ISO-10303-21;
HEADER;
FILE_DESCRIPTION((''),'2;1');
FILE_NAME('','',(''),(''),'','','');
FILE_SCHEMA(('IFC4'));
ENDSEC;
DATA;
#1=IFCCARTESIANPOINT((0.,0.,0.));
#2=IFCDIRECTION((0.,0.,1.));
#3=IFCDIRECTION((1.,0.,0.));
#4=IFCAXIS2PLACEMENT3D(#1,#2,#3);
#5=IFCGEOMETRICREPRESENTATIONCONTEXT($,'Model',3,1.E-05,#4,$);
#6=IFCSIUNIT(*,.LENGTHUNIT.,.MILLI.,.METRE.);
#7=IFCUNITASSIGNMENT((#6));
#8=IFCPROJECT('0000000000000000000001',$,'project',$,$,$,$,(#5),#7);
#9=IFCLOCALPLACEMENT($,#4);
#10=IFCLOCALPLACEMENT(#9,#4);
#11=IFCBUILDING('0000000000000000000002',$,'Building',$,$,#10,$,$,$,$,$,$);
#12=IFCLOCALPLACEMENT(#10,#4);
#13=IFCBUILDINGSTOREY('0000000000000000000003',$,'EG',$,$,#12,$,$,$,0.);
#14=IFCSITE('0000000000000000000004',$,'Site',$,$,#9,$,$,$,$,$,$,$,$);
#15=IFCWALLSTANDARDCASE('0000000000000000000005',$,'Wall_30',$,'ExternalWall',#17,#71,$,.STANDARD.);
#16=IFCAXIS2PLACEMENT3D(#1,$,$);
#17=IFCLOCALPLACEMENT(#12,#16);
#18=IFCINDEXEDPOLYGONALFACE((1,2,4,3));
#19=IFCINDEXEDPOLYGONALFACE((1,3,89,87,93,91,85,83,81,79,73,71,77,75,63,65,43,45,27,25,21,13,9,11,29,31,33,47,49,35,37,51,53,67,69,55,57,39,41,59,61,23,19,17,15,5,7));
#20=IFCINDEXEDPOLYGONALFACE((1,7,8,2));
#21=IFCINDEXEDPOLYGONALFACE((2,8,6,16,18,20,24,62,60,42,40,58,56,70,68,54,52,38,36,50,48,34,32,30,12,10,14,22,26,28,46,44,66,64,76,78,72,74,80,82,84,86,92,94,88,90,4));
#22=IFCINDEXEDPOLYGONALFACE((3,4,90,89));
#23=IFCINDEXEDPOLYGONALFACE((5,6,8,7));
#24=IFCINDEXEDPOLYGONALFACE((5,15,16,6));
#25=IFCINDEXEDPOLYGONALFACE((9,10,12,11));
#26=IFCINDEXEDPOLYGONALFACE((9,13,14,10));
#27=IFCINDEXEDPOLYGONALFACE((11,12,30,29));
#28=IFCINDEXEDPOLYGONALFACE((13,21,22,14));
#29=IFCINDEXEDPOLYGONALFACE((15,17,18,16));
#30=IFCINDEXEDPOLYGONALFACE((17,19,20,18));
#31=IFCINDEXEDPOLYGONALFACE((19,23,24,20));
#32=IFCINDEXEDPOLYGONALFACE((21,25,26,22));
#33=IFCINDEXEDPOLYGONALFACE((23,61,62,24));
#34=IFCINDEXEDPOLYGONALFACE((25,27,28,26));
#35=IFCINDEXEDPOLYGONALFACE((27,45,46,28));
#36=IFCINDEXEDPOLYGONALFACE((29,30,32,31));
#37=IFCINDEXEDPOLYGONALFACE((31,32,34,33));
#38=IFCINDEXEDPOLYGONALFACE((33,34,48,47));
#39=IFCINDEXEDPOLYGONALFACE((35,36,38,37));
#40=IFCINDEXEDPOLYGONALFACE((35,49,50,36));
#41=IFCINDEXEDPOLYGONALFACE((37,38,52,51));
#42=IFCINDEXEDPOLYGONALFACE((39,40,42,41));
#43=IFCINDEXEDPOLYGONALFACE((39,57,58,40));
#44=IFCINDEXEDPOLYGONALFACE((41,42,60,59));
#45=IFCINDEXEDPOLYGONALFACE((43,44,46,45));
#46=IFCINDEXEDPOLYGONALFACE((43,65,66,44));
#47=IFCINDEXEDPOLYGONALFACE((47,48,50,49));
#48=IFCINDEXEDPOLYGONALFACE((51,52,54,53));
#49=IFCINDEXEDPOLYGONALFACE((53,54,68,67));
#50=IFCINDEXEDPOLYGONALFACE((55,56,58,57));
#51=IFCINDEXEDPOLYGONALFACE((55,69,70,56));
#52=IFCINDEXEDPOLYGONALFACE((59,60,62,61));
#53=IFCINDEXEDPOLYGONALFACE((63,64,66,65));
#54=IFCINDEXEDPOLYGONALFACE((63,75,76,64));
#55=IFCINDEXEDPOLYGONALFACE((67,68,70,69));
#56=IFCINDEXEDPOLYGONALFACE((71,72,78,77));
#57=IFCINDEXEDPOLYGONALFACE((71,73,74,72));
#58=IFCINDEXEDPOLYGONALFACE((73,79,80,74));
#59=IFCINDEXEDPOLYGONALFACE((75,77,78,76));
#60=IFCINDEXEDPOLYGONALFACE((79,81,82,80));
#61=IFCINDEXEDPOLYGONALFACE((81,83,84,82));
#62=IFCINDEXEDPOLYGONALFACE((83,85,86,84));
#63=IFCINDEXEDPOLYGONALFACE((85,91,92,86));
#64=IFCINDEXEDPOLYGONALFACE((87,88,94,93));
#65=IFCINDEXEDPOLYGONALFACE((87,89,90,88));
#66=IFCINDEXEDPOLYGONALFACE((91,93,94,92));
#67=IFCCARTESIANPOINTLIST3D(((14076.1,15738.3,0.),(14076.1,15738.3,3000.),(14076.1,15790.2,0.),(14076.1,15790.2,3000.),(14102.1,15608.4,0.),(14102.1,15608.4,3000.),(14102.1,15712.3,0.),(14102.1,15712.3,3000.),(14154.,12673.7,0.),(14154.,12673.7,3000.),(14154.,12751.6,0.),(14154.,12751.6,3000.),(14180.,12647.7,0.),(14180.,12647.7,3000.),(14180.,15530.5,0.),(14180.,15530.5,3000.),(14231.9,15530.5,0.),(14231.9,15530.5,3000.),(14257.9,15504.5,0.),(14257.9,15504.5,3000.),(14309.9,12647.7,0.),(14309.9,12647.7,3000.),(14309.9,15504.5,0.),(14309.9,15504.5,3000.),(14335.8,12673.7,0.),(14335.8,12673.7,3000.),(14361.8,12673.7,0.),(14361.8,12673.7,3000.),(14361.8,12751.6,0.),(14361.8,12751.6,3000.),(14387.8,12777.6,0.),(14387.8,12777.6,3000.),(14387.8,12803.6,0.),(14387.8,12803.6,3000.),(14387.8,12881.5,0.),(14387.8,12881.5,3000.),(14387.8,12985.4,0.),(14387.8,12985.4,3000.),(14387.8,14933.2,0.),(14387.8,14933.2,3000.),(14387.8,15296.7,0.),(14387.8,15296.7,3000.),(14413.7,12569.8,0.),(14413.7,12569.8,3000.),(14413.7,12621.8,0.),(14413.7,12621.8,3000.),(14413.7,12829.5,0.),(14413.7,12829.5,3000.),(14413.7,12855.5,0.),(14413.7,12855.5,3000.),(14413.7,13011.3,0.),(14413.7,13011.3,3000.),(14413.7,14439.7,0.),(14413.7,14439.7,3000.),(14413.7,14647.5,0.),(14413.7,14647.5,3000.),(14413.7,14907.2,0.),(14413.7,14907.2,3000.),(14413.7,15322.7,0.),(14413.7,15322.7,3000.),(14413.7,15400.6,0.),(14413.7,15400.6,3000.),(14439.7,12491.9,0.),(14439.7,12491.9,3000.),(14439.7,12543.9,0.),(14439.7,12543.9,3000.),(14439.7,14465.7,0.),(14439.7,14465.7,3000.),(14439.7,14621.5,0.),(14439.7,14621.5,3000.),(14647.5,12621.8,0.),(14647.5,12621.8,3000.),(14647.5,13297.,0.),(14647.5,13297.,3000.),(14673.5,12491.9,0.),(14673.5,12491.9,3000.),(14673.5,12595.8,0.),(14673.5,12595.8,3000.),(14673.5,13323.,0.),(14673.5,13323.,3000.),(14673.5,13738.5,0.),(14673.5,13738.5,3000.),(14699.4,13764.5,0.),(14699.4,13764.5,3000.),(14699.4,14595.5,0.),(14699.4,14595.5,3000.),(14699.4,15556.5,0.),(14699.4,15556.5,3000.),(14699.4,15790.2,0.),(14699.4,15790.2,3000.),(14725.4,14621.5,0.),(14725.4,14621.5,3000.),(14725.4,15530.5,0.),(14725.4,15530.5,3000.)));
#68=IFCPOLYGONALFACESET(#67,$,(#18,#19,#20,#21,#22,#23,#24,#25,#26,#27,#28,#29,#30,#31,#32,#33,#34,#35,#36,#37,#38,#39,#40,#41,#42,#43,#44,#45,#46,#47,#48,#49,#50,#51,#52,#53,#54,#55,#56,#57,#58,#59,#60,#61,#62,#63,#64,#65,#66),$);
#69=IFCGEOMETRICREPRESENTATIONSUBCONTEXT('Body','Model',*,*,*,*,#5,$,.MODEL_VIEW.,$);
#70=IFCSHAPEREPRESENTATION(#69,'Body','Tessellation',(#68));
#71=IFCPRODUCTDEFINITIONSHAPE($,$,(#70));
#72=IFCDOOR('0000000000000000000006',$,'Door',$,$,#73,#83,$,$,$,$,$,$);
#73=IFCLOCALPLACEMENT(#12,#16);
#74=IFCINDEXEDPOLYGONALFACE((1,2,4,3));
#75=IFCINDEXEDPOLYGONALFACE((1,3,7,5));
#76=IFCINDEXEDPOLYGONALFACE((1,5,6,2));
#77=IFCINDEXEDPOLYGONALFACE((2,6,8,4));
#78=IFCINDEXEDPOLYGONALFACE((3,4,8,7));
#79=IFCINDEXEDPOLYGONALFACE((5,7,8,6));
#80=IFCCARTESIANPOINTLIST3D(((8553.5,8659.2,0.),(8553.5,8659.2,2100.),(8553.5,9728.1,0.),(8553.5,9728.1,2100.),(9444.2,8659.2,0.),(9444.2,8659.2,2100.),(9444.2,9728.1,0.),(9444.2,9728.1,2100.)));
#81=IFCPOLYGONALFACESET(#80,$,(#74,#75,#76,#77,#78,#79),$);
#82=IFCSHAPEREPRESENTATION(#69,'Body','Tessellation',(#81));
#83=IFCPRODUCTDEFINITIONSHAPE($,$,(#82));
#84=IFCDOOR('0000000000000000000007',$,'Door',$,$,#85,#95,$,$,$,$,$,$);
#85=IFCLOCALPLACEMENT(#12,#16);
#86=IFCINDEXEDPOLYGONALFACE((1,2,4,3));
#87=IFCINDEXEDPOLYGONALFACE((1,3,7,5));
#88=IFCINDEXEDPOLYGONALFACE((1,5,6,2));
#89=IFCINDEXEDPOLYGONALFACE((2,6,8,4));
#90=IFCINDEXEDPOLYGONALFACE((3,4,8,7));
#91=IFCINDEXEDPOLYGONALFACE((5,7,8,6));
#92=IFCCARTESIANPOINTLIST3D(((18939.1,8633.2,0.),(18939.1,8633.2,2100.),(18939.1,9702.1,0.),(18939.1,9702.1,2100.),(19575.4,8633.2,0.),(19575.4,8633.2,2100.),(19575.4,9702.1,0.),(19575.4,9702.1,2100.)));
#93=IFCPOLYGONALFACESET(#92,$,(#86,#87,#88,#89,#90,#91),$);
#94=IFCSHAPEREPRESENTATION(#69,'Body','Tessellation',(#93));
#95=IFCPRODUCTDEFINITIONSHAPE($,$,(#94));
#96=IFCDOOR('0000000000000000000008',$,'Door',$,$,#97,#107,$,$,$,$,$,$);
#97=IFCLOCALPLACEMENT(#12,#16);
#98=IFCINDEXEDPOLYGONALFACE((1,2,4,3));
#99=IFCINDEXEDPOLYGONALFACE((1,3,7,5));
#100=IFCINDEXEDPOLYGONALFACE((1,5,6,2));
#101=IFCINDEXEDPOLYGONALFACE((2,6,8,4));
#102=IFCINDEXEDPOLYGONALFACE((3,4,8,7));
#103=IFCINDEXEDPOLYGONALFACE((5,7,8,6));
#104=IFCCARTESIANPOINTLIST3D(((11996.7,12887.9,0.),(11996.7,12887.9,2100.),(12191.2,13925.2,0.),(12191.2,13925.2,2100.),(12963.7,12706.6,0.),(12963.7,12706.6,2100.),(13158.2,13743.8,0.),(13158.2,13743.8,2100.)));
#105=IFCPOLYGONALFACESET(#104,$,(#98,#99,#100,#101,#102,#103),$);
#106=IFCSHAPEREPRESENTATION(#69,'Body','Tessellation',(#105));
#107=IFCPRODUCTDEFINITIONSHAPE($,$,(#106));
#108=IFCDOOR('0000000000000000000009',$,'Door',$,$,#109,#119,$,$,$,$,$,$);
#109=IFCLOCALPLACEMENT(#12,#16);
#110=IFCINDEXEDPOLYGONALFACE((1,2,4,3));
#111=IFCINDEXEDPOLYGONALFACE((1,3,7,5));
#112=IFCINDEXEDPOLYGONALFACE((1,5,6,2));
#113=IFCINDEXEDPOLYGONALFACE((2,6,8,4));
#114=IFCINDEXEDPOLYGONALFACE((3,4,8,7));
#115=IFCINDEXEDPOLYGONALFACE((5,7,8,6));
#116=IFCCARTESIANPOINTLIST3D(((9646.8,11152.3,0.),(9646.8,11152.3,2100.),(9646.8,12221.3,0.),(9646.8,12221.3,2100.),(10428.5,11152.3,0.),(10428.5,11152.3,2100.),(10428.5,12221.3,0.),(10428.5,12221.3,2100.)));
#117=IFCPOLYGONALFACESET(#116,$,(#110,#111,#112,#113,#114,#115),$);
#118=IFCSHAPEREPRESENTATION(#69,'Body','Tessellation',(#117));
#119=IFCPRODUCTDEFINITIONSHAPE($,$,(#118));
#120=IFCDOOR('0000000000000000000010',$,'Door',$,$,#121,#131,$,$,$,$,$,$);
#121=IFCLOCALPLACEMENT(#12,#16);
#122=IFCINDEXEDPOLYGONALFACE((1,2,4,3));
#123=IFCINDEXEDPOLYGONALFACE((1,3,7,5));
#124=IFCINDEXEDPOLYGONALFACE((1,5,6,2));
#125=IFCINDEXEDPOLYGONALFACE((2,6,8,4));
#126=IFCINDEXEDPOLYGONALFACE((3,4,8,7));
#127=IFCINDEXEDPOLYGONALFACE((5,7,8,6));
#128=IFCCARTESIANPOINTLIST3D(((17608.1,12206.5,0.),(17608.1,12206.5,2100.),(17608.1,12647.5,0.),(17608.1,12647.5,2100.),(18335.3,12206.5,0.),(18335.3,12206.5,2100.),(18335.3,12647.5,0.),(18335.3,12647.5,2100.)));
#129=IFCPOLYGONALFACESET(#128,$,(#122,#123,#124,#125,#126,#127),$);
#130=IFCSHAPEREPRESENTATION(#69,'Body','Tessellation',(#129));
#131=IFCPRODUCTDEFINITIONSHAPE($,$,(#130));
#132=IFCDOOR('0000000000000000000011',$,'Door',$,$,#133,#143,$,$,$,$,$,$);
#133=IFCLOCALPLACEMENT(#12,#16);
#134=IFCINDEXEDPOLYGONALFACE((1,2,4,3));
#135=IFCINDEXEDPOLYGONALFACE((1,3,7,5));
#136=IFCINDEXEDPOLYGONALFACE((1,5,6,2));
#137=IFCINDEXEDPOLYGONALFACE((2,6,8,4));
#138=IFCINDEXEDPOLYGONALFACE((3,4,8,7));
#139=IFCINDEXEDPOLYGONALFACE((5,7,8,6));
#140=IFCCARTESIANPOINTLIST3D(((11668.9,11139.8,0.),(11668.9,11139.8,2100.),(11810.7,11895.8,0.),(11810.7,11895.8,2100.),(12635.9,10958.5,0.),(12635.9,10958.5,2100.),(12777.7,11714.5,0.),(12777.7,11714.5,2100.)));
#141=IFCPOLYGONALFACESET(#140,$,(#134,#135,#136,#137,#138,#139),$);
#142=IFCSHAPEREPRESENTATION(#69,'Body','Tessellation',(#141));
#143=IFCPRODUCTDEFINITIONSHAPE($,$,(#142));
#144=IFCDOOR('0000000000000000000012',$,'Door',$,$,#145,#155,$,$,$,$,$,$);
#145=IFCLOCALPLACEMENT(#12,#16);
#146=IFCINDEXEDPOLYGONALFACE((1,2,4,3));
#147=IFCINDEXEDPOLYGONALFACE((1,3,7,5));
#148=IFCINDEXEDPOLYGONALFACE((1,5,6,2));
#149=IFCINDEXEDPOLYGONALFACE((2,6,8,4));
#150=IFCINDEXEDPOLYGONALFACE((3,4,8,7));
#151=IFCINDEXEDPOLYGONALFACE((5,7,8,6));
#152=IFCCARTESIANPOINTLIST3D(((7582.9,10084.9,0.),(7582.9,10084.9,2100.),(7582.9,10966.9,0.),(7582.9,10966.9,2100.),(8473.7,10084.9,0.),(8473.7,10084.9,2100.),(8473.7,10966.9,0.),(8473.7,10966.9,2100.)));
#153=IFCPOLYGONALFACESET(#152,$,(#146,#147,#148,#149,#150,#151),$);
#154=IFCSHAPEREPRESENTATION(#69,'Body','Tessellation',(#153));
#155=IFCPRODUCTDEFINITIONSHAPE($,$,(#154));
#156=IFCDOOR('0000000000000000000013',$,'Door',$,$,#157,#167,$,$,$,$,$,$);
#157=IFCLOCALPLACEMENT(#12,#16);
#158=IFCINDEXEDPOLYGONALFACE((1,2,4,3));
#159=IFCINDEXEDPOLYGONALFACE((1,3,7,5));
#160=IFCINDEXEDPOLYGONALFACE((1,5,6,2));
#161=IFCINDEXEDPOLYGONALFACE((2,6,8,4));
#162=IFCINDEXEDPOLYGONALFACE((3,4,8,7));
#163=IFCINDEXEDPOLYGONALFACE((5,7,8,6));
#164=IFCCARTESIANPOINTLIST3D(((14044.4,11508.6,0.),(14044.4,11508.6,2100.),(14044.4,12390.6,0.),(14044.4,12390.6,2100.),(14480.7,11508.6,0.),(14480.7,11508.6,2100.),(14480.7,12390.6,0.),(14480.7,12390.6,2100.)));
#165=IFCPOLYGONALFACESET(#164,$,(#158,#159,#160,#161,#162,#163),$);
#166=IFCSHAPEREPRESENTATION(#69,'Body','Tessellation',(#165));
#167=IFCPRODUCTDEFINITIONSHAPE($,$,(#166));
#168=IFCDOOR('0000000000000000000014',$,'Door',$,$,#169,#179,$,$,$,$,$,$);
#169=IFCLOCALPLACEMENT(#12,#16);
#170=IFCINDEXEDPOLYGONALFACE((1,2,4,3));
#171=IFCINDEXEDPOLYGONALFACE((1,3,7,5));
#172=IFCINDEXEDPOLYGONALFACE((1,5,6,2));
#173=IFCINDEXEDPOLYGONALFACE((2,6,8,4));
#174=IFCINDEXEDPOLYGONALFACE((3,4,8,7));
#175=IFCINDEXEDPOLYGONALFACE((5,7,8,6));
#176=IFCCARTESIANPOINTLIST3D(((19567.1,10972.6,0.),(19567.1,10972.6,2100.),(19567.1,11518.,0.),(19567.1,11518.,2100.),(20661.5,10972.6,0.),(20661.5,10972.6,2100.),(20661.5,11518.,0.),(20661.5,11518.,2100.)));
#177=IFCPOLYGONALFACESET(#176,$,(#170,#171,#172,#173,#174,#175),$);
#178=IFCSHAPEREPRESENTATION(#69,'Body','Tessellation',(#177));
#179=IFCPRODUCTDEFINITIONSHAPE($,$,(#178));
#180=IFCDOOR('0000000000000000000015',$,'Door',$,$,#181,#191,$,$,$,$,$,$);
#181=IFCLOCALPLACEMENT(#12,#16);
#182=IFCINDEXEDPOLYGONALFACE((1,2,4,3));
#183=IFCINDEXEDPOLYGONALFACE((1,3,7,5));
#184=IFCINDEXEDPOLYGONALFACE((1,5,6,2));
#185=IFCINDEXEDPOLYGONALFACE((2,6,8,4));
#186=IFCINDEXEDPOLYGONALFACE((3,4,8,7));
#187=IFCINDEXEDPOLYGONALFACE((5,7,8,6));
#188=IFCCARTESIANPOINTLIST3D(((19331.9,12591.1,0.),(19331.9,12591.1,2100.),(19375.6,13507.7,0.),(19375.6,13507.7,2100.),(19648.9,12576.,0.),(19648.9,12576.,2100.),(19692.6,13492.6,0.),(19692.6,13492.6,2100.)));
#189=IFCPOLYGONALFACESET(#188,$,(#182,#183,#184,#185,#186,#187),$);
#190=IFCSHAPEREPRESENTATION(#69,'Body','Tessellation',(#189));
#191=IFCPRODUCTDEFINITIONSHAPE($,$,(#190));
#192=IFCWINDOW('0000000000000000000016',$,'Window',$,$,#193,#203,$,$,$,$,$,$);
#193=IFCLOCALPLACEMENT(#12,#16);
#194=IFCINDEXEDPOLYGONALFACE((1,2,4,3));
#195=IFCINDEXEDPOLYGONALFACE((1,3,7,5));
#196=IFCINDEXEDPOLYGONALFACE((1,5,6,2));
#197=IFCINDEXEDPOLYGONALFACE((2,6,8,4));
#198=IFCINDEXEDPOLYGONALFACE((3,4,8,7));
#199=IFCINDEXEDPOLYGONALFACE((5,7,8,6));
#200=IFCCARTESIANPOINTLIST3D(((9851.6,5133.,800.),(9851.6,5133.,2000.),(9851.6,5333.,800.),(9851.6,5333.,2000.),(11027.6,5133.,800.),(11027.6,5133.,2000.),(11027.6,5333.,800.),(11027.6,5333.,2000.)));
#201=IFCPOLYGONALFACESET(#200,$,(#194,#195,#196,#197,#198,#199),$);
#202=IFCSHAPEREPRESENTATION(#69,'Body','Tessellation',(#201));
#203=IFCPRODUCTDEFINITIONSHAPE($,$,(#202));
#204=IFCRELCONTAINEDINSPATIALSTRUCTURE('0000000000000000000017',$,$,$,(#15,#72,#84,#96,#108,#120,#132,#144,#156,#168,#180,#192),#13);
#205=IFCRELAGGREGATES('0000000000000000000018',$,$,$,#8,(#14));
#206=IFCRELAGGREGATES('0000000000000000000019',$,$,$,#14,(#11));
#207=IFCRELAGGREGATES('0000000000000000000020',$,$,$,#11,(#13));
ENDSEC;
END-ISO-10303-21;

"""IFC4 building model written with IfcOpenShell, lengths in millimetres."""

from ifc_helpers import new_model, si_unit, frame, origin_with_axes, place, context, subcontext, project, spatial, polyline, rectangle, outline, extrude, element, save


model = new_model("IFC4")

# Units and contexts
model_context = context("Model", 3, precision=1e-05, world=origin_with_axes())
body_context = subcontext(model_context, "Body", "Model", "MODEL_VIEW")
ifc_project = project(units=[si_unit("LENGTHUNIT", "METRE", prefix="MILLI")], contexts=[model_context])

# Site, building, storey
site_placement = place(None, origin_with_axes())
site = spatial("IfcSite", under=ifc_project, at=site_placement, Name="Site")
building_placement = place(site_placement, origin_with_axes())
building = spatial("IfcBuilding", under=site, at=building_placement, Name="Building")
storey_placement = place(building_placement, origin_with_axes())
storey = spatial("IfcBuildingStorey", under=building, at=storey_placement, Name="EG", Elevation=0.0)

# Wall
wall_placement = place(storey_placement, origin_with_axes())
element("IfcWallStandardCase", 1, at=wall_placement, inside=storey, Name="Wall_30", ObjectType="ExternalWall", PredefinedType="STANDARD", context=body_context, shape_type="SweptSolid", body=[
    extrude(outline(polyline([(14439.7, 12491.9, 0.0), (14439.7, 12543.9, 0.0), (14413.7, 12569.8, 0.0), (14413.7, 12621.8, 0.0), (14361.8, 12673.7, 0.0), (14335.8, 12673.7, 0.0), (14309.9, 12647.7, 0.0), (14180.0, 12647.7, 0.0), (14154.0, 12673.7, 0.0), (14154.0, 12751.6, 0.0), (14361.8, 12751.6, 0.0), (14387.8, 12777.6, 0.0), (14387.8, 12803.6, 0.0), (14413.7, 12829.5, 0.0), (14413.7, 12855.5, 0.0), (14387.8, 12881.5, 0.0), (14387.8, 12985.4, 0.0), (14413.7, 13011.3, 0.0), (14413.7, 14439.7, 0.0), (14439.7, 14465.7, 0.0), (14439.7, 14621.5, 0.0), (14413.7, 14647.5, 0.0), (14413.7, 14907.2, 0.0), (14387.8, 14933.2, 0.0), (14387.8, 15296.7, 0.0), (14413.7, 15322.7, 0.0), (14413.7, 15400.6, 0.0), (14309.9, 15504.5, 0.0), (14257.9, 15504.5, 0.0), (14231.9, 15530.5, 0.0), (14180.0, 15530.5, 0.0), (14102.1, 15608.4, 0.0), (14102.1, 15712.3, 0.0), (14076.1, 15738.3, 0.0), (14076.1, 15790.2, 0.0), (14699.4, 15790.2, 0.0), (14699.4, 15556.5, 0.0), (14725.4, 15530.5, 0.0), (14725.4, 14621.5, 0.0), (14699.4, 14595.5, 0.0), (14699.4, 13764.5, 0.0), (14673.5, 13738.5, 0.0), (14673.5, 13323.0, 0.0), (14647.5, 13297.0, 0.0), (14647.5, 12621.8, 0.0), (14673.5, 12595.8, 0.0), (14673.5, 12491.9, 0.0), (14439.7, 12491.9, 0.0)])), origin_with_axes(), (0.0, 0.0, 1.0), 3000.0),
])

# Doors
door_1_placement = place(storey_placement, origin_with_axes())
element("IfcDoor", 2, at=door_1_placement, inside=storey, Name="Door", context=body_context, shape_type="SweptSolid", body=[
    extrude(rectangle(XDim=1069.0, YDim=890.8), frame((8998.9, 9193.6, 0.0), z_axis=(0.0, 0.0, 1.0), x_axis=(0.0, 1.0, 0.0)), (0.0, 0.0, 1.0), 2100.0),
])
door_2_placement = place(storey_placement, origin_with_axes())
element("IfcDoor", 3, at=door_2_placement, inside=storey, Name="Door", context=body_context, shape_type="SweptSolid", body=[
    extrude(rectangle(XDim=1069.0, YDim=636.3), frame((19257.3, 9167.7, 0.0), z_axis=(0.0, 0.0, 1.0), x_axis=(0.0, -1.0, 0.0)), (0.0, 0.0, 1.0), 2100.0),
])
door_3_placement = place(storey_placement, origin_with_axes())
element("IfcDoor", 4, at=door_3_placement, inside=storey, Name="Door", context=body_context, shape_type="SweptSolid", body=[
    extrude(rectangle(XDim=1055.3, YDim=983.9), frame((12577.4, 13315.9, 0.0), z_axis=(0.0, 0.0, 1.0), x_axis=(0.184288, 0.982872, 0.0)), (0.0, 0.0, 1.0), 2100.0),
])
door_4_placement = place(storey_placement, origin_with_axes())
element("IfcDoor", 5, at=door_4_placement, inside=storey, Name="Door", context=body_context, shape_type="SweptSolid", body=[
    extrude(rectangle(XDim=1069.0, YDim=781.7), frame((10037.7, 11686.8, 0.0), z_axis=(0.0, 0.0, 1.0), x_axis=(0.0, -1.0, 0.0)), (0.0, 0.0, 1.0), 2100.0),
])
door_5_placement = place(storey_placement, origin_with_axes())
element("IfcDoor", 6, at=door_5_placement, inside=storey, Name="Door", context=body_context, shape_type="SweptSolid", body=[
    extrude(rectangle(XDim=441.0, YDim=727.2), frame((17971.7, 12427.0, 0.0), z_axis=(0.0, 0.0, 1.0), x_axis=(0.0, 1.0, 0.0)), (0.0, 0.0, 1.0), 2100.0),
])
door_6_placement = place(storey_placement, origin_with_axes())
element("IfcDoor", 7, at=door_6_placement, inside=storey, Name="Door", context=body_context, shape_type="SweptSolid", body=[
    extrude(rectangle(XDim=769.2, YDim=983.9), frame((12223.3, 11427.2, 0.0), z_axis=(0.0, 0.0, 1.0), x_axis=(0.184288, 0.982872, 0.0)), (0.0, 0.0, 1.0), 2100.0),
])
door_7_placement = place(storey_placement, origin_with_axes())
element("IfcDoor", 8, at=door_7_placement, inside=storey, Name="Door", context=body_context, shape_type="SweptSolid", body=[
    extrude(rectangle(XDim=882.0, YDim=890.8), frame((8028.3, 10525.9, 0.0), z_axis=(0.0, 0.0, 1.0), x_axis=(0.0, 1.0, 0.0)), (0.0, 0.0, 1.0), 2100.0),
])
door_8_placement = place(storey_placement, origin_with_axes())
element("IfcDoor", 9, at=door_8_placement, inside=storey, Name="Door", context=body_context, shape_type="SweptSolid", body=[
    extrude(rectangle(XDim=882.0, YDim=436.3), frame((14262.5, 11949.6, 0.0), z_axis=(0.0, 0.0, 1.0), x_axis=(0.0, -1.0, 0.0)), (0.0, 0.0, 1.0), 2100.0),
])
door_9_placement = place(storey_placement, origin_with_axes())
element("IfcDoor", 10, at=door_9_placement, inside=storey, Name="Door", context=body_context, shape_type="SweptSolid", body=[
    extrude(rectangle(XDim=1094.4, YDim=545.4), frame((20114.3, 11245.3, 0.0), z_axis=(0.0, 0.0, 1.0), x_axis=(1.0, 0.0, 0.0)), (0.0, 0.0, 1.0), 2100.0),
])
door_10_placement = place(storey_placement, origin_with_axes())
element("IfcDoor", 11, at=door_10_placement, inside=storey, Name="Door", context=body_context, shape_type="SweptSolid", body=[
    extrude(rectangle(XDim=917.6, YDim=317.3), frame((19512.3, 13041.9, 0.0), z_axis=(0.0, 0.0, 1.0), x_axis=(-0.047565, -0.998868, 0.0)), (0.0, 0.0, 1.0), 2100.0),
])

# Window
window_1_placement = place(storey_placement, origin_with_axes())
element("IfcWindow", 12, at=window_1_placement, inside=storey, Name="Window", context=body_context, shape_type="SweptSolid", body=[
    extrude(rectangle(XDim=1176.0, YDim=200.0), frame((10439.6, 5233.0, 800.0), z_axis=(0.0, 0.0, 1.0), x_axis=(1.0, 0.0, 0.0)), (0.0, 0.0, 1.0), 1200.0),
])

save(model, "model.ifc")
